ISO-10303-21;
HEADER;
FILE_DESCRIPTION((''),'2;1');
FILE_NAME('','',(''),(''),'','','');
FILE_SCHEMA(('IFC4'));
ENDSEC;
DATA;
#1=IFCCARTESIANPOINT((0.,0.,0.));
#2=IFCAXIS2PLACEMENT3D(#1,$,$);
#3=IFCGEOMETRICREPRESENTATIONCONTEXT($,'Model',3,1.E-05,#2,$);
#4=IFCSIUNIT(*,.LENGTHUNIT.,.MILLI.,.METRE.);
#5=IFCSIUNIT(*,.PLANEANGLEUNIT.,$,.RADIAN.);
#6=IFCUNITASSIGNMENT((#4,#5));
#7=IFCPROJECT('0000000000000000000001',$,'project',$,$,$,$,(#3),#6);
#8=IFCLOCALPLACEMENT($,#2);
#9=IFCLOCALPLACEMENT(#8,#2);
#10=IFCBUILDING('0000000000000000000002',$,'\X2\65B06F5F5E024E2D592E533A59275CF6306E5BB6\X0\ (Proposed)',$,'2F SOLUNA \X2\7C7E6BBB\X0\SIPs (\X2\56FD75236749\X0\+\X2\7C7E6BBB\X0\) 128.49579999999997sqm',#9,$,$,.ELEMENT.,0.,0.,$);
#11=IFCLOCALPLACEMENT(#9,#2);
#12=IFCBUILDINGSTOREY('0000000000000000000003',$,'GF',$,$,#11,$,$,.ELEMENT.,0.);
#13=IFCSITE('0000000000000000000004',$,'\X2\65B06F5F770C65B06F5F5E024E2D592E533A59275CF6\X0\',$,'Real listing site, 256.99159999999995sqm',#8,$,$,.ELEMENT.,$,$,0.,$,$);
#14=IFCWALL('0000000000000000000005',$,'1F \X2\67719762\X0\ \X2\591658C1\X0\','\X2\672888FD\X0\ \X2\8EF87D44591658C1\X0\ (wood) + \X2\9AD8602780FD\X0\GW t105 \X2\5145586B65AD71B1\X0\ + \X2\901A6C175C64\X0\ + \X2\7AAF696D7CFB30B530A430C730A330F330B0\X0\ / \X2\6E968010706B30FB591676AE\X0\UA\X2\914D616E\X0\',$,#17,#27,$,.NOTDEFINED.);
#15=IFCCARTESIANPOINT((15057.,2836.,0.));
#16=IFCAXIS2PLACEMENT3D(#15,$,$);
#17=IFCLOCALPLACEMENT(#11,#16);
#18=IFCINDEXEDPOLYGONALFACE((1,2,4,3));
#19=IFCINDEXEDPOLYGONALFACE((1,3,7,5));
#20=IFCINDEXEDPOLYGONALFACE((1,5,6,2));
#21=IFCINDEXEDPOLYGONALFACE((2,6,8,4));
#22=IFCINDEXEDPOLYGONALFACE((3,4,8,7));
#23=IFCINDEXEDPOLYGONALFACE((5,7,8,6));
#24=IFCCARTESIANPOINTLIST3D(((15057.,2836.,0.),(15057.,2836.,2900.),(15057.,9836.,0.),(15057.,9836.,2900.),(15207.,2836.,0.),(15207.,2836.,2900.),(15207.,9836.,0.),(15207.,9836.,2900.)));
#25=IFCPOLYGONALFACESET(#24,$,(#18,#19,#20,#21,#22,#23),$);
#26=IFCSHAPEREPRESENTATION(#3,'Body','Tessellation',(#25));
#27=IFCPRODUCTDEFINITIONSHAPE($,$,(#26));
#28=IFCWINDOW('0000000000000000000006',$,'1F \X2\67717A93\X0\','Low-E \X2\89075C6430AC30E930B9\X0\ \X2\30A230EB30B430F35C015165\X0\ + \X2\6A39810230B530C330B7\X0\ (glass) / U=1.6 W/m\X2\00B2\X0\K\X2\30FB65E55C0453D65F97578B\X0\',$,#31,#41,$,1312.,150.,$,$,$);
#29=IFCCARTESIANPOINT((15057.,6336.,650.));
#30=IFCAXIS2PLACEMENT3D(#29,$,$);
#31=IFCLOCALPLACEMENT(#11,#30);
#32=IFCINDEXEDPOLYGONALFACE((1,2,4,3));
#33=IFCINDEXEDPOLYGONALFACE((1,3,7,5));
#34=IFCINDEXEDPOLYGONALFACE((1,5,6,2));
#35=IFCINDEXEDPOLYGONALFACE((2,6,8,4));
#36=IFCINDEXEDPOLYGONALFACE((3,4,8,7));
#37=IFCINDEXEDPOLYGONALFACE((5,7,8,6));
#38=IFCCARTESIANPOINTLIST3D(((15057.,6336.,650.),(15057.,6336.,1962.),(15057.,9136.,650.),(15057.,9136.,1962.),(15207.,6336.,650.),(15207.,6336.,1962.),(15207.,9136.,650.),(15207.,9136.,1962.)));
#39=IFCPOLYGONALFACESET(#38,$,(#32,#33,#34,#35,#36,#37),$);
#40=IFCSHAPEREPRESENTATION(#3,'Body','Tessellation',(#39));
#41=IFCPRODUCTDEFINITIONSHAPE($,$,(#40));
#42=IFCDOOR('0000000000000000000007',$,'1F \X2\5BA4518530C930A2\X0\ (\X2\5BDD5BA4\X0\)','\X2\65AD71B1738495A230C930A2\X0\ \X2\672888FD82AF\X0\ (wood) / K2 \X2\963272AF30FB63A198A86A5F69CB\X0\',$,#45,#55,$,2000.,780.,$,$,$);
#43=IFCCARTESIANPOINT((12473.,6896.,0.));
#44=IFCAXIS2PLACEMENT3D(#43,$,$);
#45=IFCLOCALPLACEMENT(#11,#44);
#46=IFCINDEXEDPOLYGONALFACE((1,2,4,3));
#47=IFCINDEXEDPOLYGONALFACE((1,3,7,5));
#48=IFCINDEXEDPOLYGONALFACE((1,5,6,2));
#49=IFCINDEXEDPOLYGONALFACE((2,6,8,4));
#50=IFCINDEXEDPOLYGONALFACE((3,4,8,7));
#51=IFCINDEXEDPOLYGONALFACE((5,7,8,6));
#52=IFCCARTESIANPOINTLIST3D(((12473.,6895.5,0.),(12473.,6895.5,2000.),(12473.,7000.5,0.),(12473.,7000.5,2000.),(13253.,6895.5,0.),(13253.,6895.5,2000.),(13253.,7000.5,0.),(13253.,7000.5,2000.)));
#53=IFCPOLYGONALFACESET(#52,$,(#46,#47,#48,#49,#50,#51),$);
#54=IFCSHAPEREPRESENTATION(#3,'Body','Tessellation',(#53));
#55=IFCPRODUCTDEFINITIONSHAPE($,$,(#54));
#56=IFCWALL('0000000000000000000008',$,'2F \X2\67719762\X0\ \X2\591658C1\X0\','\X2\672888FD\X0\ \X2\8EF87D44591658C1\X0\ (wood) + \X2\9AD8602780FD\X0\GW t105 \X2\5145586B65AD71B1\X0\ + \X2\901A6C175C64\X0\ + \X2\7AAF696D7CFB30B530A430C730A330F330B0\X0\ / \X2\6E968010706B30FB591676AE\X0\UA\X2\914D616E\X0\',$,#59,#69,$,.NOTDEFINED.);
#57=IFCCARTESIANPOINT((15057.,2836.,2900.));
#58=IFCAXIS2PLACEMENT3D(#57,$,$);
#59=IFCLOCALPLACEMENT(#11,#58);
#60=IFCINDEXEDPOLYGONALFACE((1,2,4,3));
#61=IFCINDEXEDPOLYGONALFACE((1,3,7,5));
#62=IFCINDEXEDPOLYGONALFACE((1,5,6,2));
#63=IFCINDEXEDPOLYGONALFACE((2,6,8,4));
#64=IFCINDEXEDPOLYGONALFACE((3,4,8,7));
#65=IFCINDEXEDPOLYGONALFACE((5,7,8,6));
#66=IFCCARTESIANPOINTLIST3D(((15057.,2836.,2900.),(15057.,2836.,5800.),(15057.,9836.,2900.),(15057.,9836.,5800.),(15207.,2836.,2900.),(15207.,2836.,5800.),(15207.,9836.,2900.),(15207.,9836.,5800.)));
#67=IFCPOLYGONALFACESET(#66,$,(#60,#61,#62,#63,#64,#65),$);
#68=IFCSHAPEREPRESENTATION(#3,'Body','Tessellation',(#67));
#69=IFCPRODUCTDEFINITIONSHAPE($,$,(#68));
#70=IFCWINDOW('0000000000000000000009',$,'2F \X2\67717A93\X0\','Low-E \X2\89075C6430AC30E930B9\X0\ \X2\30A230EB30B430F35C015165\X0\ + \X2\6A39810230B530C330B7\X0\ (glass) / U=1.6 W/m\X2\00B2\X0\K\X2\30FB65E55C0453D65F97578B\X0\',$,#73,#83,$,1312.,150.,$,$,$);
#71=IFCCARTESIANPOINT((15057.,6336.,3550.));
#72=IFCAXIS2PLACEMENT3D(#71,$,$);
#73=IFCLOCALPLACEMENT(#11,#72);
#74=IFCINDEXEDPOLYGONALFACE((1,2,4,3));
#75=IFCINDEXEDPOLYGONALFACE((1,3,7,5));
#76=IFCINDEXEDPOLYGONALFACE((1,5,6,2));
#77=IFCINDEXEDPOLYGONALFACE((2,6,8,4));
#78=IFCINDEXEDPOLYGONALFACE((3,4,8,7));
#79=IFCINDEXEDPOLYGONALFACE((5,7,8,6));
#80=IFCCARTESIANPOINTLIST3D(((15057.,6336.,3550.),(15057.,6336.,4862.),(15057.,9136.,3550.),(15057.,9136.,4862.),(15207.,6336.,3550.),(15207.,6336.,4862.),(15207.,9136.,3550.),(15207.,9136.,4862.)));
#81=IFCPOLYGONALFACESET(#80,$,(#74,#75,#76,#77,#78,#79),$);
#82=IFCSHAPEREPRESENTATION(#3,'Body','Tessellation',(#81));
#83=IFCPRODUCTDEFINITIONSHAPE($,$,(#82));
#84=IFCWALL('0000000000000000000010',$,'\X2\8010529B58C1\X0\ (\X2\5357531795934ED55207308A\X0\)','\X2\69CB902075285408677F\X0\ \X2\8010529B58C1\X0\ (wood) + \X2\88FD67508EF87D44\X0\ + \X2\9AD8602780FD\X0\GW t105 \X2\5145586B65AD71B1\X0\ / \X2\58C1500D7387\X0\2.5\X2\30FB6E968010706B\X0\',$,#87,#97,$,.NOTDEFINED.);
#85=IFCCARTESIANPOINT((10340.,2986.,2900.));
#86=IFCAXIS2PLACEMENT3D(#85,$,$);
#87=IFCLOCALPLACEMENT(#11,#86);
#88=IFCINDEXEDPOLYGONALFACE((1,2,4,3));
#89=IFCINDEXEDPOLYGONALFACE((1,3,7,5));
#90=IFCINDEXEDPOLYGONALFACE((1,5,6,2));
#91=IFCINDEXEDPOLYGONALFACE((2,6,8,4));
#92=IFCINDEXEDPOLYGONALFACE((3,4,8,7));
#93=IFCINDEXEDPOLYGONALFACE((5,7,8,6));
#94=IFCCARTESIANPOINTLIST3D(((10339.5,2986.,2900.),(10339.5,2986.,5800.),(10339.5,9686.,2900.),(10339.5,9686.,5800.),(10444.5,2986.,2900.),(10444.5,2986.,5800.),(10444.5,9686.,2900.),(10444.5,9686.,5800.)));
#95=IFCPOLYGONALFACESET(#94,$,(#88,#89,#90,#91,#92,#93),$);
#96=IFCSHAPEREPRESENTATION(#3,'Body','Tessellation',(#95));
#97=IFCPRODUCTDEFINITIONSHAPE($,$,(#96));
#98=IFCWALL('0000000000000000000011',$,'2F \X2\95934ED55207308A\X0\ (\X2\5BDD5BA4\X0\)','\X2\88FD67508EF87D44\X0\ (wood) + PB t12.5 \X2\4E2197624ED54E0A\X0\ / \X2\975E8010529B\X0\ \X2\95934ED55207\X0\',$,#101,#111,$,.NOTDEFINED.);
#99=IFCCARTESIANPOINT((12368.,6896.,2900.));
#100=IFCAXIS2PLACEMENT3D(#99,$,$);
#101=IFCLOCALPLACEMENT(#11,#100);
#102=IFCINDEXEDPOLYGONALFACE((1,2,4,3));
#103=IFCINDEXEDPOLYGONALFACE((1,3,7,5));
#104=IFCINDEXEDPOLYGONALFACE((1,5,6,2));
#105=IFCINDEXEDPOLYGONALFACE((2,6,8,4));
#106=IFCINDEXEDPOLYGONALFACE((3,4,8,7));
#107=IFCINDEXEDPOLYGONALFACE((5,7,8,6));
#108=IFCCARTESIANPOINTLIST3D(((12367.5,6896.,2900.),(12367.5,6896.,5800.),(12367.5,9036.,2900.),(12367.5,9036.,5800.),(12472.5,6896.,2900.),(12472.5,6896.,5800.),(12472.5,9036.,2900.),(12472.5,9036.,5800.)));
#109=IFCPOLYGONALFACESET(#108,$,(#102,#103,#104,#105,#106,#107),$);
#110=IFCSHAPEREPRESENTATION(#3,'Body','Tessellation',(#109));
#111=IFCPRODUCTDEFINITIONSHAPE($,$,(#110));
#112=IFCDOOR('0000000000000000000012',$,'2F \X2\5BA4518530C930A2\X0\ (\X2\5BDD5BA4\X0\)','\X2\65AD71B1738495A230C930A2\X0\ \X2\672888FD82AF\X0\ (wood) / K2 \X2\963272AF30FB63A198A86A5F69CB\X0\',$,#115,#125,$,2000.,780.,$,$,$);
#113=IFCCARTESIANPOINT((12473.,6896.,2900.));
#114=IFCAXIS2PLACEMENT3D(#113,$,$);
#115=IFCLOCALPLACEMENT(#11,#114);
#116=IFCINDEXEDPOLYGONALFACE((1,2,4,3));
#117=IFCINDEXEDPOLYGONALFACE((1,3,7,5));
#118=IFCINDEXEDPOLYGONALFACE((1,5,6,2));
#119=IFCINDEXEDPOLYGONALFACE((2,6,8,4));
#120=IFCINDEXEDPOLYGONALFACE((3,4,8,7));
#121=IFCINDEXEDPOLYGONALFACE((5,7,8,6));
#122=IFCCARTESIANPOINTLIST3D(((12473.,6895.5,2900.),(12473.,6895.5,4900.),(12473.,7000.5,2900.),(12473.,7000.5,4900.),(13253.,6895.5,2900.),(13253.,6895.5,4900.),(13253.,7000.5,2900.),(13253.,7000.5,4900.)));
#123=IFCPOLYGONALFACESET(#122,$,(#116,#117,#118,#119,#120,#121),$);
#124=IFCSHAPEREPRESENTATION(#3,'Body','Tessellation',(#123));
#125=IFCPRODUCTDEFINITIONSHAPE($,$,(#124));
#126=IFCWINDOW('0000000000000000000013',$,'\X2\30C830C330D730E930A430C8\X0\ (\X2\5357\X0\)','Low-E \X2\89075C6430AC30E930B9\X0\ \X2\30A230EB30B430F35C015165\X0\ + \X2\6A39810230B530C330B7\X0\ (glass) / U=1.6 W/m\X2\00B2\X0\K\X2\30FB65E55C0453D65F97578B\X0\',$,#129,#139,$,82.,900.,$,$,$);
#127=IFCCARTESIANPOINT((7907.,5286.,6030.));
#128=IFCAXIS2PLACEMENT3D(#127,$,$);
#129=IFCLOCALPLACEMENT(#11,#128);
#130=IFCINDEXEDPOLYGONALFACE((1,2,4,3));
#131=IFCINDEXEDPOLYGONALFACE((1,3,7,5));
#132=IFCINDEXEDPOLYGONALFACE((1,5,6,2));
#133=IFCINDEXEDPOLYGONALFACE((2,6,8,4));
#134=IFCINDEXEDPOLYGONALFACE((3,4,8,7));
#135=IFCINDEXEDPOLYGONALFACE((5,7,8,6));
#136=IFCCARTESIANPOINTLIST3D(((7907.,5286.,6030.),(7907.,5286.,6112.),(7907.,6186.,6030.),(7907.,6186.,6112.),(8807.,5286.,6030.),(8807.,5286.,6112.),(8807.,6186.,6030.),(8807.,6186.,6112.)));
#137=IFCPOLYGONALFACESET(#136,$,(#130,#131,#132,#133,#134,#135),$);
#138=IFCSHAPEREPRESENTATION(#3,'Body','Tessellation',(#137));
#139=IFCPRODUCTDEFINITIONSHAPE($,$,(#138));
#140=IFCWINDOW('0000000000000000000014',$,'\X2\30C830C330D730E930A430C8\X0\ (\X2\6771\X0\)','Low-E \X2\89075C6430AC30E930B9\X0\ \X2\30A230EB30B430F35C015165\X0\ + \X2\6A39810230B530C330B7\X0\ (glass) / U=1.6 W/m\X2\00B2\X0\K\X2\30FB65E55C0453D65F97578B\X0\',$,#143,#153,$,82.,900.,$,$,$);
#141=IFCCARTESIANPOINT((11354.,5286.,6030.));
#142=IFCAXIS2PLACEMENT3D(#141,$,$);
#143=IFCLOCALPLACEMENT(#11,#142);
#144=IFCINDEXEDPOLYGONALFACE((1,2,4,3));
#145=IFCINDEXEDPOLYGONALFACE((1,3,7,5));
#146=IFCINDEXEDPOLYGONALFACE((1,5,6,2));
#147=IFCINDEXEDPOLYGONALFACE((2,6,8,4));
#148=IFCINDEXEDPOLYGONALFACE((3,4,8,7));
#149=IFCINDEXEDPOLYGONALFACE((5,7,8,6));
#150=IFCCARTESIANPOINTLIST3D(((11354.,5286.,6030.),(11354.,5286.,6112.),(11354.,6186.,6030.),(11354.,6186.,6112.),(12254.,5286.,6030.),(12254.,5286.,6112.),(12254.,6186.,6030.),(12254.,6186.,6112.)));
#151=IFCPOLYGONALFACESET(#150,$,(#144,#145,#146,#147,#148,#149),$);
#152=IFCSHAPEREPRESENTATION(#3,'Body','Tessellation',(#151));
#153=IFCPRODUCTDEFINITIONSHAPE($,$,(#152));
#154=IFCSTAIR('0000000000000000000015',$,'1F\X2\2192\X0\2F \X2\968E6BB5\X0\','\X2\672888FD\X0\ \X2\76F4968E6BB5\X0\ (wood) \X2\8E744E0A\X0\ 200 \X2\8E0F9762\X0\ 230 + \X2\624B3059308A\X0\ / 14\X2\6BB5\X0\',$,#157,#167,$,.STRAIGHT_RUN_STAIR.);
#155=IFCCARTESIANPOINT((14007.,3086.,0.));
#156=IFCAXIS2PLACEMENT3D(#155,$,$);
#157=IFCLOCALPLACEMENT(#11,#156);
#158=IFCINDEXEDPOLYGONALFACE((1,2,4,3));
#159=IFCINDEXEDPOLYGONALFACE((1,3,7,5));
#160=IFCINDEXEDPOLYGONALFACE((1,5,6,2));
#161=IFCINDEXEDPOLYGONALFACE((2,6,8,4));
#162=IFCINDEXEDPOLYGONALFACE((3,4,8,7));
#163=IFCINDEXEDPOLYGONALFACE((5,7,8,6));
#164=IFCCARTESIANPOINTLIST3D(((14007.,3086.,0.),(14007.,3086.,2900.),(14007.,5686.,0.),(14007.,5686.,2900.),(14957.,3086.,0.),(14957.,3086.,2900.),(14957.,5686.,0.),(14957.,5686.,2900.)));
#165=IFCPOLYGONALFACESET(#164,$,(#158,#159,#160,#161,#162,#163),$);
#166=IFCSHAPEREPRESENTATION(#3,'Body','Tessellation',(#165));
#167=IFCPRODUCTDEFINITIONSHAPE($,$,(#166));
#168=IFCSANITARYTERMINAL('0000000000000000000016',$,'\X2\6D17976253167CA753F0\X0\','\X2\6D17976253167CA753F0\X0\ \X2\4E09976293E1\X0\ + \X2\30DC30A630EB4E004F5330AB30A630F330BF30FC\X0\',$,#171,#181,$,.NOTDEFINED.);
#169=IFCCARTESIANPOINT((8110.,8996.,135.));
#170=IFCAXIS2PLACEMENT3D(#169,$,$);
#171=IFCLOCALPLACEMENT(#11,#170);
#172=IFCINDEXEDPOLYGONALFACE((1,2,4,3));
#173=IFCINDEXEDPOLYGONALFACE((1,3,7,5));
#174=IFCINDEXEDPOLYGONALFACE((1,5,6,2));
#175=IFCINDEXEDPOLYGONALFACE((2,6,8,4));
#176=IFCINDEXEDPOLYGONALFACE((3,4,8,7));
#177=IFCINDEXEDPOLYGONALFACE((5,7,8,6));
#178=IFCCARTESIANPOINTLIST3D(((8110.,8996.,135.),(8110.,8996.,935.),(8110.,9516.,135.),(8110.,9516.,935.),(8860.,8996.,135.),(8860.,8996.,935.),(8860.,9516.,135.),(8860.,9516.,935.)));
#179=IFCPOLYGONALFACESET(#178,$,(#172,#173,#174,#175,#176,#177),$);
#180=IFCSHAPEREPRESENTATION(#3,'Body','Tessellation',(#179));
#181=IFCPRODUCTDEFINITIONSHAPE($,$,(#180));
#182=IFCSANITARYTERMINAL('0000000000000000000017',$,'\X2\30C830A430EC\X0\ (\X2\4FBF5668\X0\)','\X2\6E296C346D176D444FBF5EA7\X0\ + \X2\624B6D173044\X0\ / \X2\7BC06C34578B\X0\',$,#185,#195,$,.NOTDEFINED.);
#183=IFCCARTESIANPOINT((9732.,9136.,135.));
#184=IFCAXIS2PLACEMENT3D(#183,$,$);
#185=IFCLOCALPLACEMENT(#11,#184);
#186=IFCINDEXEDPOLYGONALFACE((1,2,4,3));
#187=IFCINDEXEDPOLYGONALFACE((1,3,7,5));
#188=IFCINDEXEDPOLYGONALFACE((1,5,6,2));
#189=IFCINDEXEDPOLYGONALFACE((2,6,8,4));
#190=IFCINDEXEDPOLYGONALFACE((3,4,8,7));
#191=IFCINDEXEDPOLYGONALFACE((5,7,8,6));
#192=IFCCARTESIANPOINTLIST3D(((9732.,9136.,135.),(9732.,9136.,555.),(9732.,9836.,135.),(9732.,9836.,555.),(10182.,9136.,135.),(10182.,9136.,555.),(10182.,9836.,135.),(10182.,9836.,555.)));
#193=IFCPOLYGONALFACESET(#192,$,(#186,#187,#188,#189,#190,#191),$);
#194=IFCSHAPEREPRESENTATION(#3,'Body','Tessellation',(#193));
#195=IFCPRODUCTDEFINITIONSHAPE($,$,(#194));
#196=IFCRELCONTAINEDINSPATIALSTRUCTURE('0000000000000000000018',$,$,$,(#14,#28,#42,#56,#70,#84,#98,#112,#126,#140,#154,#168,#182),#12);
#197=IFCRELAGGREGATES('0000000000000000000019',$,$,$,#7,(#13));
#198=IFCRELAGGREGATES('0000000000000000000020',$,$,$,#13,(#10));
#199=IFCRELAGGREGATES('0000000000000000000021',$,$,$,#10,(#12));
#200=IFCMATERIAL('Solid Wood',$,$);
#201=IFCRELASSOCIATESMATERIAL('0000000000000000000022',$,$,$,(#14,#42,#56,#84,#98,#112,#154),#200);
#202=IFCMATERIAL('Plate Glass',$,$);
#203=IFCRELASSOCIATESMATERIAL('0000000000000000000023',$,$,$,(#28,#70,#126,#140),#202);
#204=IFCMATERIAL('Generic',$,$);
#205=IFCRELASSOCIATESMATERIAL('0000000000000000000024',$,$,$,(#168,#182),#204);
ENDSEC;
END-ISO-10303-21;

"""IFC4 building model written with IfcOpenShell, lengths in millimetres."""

from ifc_helpers import new_model, si_unit, frame, frame_2d, origin, place, context, project, spatial, rectangle, extrude, material, element, fill, save


model = new_model("IFC4")

# Units and contexts
model_context = context("Model", 3, precision=1e-05, world=origin())
ifc_project = project(units=[si_unit("LENGTHUNIT", "METRE", prefix="MILLI"), si_unit("PLANEANGLEUNIT", "RADIAN")], contexts=[model_context])

# Site, building, storey
site_placement = place(None, origin())
site = spatial("IfcSite", under=ifc_project, at=site_placement, Name="新潟県新潟市中央区大島", ObjectType="Real listing site, 256.99159999999995sqm", CompositionType="ELEMENT", RefElevation=0.0)
building_placement = place(site_placement, origin())
building = spatial("IfcBuilding", under=site, at=building_placement, Name="新潟市中央区大島の家 (Proposed)", ObjectType="2F SOLUNA 籾殻SIPs (国産杉+籾殻) 128.49579999999997sqm", CompositionType="ELEMENT", ElevationOfRefHeight=0.0, ElevationOfTerrain=0.0)
storey_placement = place(building_placement, origin())
storey = spatial("IfcBuildingStorey", under=building, at=storey_placement, Name="GF", CompositionType="ELEMENT", Elevation=0.0)

# Wall, opening, window
ifc_material_1 = material(Name="Solid Wood")
wall_1_placement = place(storey_placement, frame((15057.0, 2836.0, 0.0)))
wall_1 = element("IfcWall", 1, at=wall_1_placement, inside=storey, material=ifc_material_1, Name="1F 東面 外壁", Description="木製 軸組外壁 (wood) + 高性能GW t105 充填断熱 + 通気層 + 窯業系サイディング / 準耐火・外皮UA配慮", PredefinedType="NOTDEFINED", context=model_context, shape_type="SweptSolid", body=[
    extrude(rectangle(XDim=150.0, YDim=7000.0, at=frame_2d((75.0, 3500.0))), frame((15057.0, 2836.0, 0.0)), (0.0, 0.0, 1.0), 2900.0),
])
opening_1_placement = place(storey_placement, frame((15057.0, 6336.0, 650.0)))
opening_1 = element("IfcOpeningElement", 2, at=opening_1_placement, cuts=wall_1, PredefinedType="NOTDEFINED", context=model_context, shape_type="SweptSolid", body=[
    extrude(rectangle(XDim=150.0, YDim=2800.0, at=frame_2d((75.0, 1400.0))), frame((15057.0, 6336.0, 650.0)), (0.0, 0.0, 1.0), 1312.0),
])
ifc_material_2 = material(Name="Plate Glass")
window_1_placement = place(storey_placement, frame((15057.0, 6336.0, 650.0)))
window_1 = element("IfcWindow", 3, at=window_1_placement, inside=storey, material=ifc_material_2, Name="1F 東窓", Description="Low-E 複層ガラス アルゴン封入 + 樹脂サッシ (glass) / U=1.6 W/m²K・日射取得型", OverallHeight=1312.0, OverallWidth=150.0, context=model_context, shape_type="SweptSolid", body=[
    extrude(rectangle(XDim=150.0, YDim=2800.0, at=frame_2d((75.0, 1400.0))), frame((15057.0, 6336.0, 650.0)), (0.0, 0.0, 1.0), 1312.0),
])
fill(opening_1, window_1)

# Door
door_1_placement = place(storey_placement, frame((12473.0, 6896.0, 0.0)))
element("IfcDoor", 4, at=door_1_placement, inside=storey, material=ifc_material_1, Name="1F 室内ドア (寝室)", Description="断熱玄関ドア 木製芯 (wood) / K2 防犯・採風機構", OverallHeight=2000.0, OverallWidth=780.0, context=model_context, shape_type="SweptSolid", body=[
    extrude(rectangle(XDim=780.0, YDim=105.0, at=frame_2d((390.0, 52.0))), frame((12473.0, 6896.0, 0.0)), (0.0, 0.0, 1.0), 2000.0),
])

# Wall, opening, window
wall_2_placement = place(storey_placement, frame((15057.0, 2836.0, 2900.0)))
wall_2 = element("IfcWall", 5, at=wall_2_placement, inside=storey, material=ifc_material_1, Name="2F 東面 外壁", Description="木製 軸組外壁 (wood) + 高性能GW t105 充填断熱 + 通気層 + 窯業系サイディング / 準耐火・外皮UA配慮", PredefinedType="NOTDEFINED", context=model_context, shape_type="SweptSolid", body=[
    extrude(rectangle(XDim=150.0, YDim=7000.0, at=frame_2d((75.0, 3500.0))), frame((15057.0, 2836.0, 2900.0)), (0.0, 0.0, 1.0), 2900.0),
])
opening_2_placement = place(storey_placement, frame((15057.0, 6336.0, 3550.0)))
opening_2 = element("IfcOpeningElement", 6, at=opening_2_placement, cuts=wall_2, PredefinedType="NOTDEFINED", context=model_context, shape_type="SweptSolid", body=[
    extrude(rectangle(XDim=150.0, YDim=2800.0, at=frame_2d((75.0, 1400.0))), frame((15057.0, 6336.0, 3550.0)), (0.0, 0.0, 1.0), 1312.0),
])
window_2_placement = place(storey_placement, frame((15057.0, 6336.0, 3550.0)))
window_2 = element("IfcWindow", 7, at=window_2_placement, inside=storey, material=ifc_material_2, Name="2F 東窓", Description="Low-E 複層ガラス アルゴン封入 + 樹脂サッシ (glass) / U=1.6 W/m²K・日射取得型", OverallHeight=1312.0, OverallWidth=150.0, context=model_context, shape_type="SweptSolid", body=[
    extrude(rectangle(XDim=150.0, YDim=2800.0, at=frame_2d((75.0, 1400.0))), frame((15057.0, 6336.0, 3550.0)), (0.0, 0.0, 1.0), 1312.0),
])
fill(opening_2, window_2)

# Walls
wall_3_placement = place(storey_placement, frame((10340.0, 2986.0, 2900.0)))
element("IfcWall", 8, at=wall_3_placement, inside=storey, material=ifc_material_1, Name="耐力壁 (南北間仕切り)", Description="構造用合板 耐力壁 (wood) + 製材軸組 + 高性能GW t105 充填断熱 / 壁倍率2.5・準耐火", PredefinedType="NOTDEFINED", context=model_context, shape_type="SweptSolid", body=[
    extrude(rectangle(XDim=105.0, YDim=6700.0, at=frame_2d((52.0, 3350.0))), frame((10340.0, 2986.0, 2900.0)), (0.0, 0.0, 1.0), 2900.0),
])
wall_4_placement = place(storey_placement, frame((12368.0, 6896.0, 2900.0)))
element("IfcWall", 9, at=wall_4_placement, inside=storey, material=ifc_material_1, Name="2F 間仕切り (寝室)", Description="製材軸組 (wood) + PB t12.5 両面仕上 / 非耐力 間仕切", PredefinedType="NOTDEFINED", context=model_context, shape_type="SweptSolid", body=[
    extrude(rectangle(XDim=105.0, YDim=2140.0, at=frame_2d((52.0, 1070.0))), frame((12368.0, 6896.0, 2900.0)), (0.0, 0.0, 1.0), 2900.0),
])

# Door
door_2_placement = place(storey_placement, frame((12473.0, 6896.0, 2900.0)))
element("IfcDoor", 10, at=door_2_placement, inside=storey, material=ifc_material_1, Name="2F 室内ドア (寝室)", Description="断熱玄関ドア 木製芯 (wood) / K2 防犯・採風機構", OverallHeight=2000.0, OverallWidth=780.0, context=model_context, shape_type="SweptSolid", body=[
    extrude(rectangle(XDim=780.0, YDim=105.0, at=frame_2d((390.0, 52.0))), frame((12473.0, 6896.0, 2900.0)), (0.0, 0.0, 1.0), 2000.0),
])

# Windows
window_3_placement = place(storey_placement, frame((7907.0, 5286.0, 6030.0)))
element("IfcWindow", 11, at=window_3_placement, inside=storey, material=ifc_material_2, Name="トップライト (南)", Description="Low-E 複層ガラス アルゴン封入 + 樹脂サッシ (glass) / U=1.6 W/m²K・日射取得型", OverallHeight=82.0, OverallWidth=900.0, context=model_context, shape_type="SweptSolid", body=[
    extrude(rectangle(XDim=900.0, YDim=900.0, at=frame_2d((450.0, 450.0))), frame((7907.0, 5286.0, 6030.0)), (0.0, 0.0, 1.0), 82.0),
])
window_4_placement = place(storey_placement, frame((11354.0, 5286.0, 6030.0)))
element("IfcWindow", 12, at=window_4_placement, inside=storey, material=ifc_material_2, Name="トップライト (東)", Description="Low-E 複層ガラス アルゴン封入 + 樹脂サッシ (glass) / U=1.6 W/m²K・日射取得型", OverallHeight=82.0, OverallWidth=900.0, context=model_context, shape_type="SweptSolid", body=[
    extrude(rectangle(XDim=900.0, YDim=900.0, at=frame_2d((450.0, 450.0))), frame((11354.0, 5286.0, 6030.0)), (0.0, 0.0, 1.0), 82.0),
])

# Stair
stair_placement = place(storey_placement, frame((14007.0, 3086.0, 0.0)))
element("IfcStair", 13, at=stair_placement, inside=storey, material=ifc_material_1, Name="1F→2F 階段", Description="木製 直階段 (wood) 蹴上 200 踏面 230 + 手すり / 14段", PredefinedType="STRAIGHT_RUN_STAIR", context=model_context, shape_type="SweptSolid", body=[
    extrude(rectangle(XDim=950.0, YDim=2600.0, at=frame_2d((475.0, 1300.0))), frame((14007.0, 3086.0, 0.0)), (0.0, 0.0, 1.0), 2900.0),
])

# Sanitary terminals
ifc_material_3 = material(Name="Generic")
sanitary_terminal_1_placement = place(storey_placement, frame((8110.0, 8996.0, 135.0)))
element("IfcSanitaryTerminal", 14, at=sanitary_terminal_1_placement, inside=storey, material=ifc_material_3, Name="洗面化粧台", Description="洗面化粧台 三面鏡 + ボウル一体カウンター", PredefinedType="NOTDEFINED", context=model_context, shape_type="SweptSolid", body=[
    extrude(rectangle(XDim=750.0, YDim=520.0, at=frame_2d((375.0, 260.0))), frame((8110.0, 8996.0, 135.0)), (0.0, 0.0, 1.0), 800.0),
])
sanitary_terminal_2_placement = place(storey_placement, frame((9732.0, 9136.0, 135.0)))
element("IfcSanitaryTerminal", 15, at=sanitary_terminal_2_placement, inside=storey, material=ifc_material_3, Name="トイレ (便器)", Description="温水洗浄便座 + 手洗い / 節水型", PredefinedType="NOTDEFINED", context=model_context, shape_type="SweptSolid", body=[
    extrude(rectangle(XDim=450.0, YDim=700.0, at=frame_2d((225.0, 350.0))), frame((9732.0, 9136.0, 135.0)), (0.0, 0.0, 1.0), 420.0),
])

save(model, "model.ifc")
